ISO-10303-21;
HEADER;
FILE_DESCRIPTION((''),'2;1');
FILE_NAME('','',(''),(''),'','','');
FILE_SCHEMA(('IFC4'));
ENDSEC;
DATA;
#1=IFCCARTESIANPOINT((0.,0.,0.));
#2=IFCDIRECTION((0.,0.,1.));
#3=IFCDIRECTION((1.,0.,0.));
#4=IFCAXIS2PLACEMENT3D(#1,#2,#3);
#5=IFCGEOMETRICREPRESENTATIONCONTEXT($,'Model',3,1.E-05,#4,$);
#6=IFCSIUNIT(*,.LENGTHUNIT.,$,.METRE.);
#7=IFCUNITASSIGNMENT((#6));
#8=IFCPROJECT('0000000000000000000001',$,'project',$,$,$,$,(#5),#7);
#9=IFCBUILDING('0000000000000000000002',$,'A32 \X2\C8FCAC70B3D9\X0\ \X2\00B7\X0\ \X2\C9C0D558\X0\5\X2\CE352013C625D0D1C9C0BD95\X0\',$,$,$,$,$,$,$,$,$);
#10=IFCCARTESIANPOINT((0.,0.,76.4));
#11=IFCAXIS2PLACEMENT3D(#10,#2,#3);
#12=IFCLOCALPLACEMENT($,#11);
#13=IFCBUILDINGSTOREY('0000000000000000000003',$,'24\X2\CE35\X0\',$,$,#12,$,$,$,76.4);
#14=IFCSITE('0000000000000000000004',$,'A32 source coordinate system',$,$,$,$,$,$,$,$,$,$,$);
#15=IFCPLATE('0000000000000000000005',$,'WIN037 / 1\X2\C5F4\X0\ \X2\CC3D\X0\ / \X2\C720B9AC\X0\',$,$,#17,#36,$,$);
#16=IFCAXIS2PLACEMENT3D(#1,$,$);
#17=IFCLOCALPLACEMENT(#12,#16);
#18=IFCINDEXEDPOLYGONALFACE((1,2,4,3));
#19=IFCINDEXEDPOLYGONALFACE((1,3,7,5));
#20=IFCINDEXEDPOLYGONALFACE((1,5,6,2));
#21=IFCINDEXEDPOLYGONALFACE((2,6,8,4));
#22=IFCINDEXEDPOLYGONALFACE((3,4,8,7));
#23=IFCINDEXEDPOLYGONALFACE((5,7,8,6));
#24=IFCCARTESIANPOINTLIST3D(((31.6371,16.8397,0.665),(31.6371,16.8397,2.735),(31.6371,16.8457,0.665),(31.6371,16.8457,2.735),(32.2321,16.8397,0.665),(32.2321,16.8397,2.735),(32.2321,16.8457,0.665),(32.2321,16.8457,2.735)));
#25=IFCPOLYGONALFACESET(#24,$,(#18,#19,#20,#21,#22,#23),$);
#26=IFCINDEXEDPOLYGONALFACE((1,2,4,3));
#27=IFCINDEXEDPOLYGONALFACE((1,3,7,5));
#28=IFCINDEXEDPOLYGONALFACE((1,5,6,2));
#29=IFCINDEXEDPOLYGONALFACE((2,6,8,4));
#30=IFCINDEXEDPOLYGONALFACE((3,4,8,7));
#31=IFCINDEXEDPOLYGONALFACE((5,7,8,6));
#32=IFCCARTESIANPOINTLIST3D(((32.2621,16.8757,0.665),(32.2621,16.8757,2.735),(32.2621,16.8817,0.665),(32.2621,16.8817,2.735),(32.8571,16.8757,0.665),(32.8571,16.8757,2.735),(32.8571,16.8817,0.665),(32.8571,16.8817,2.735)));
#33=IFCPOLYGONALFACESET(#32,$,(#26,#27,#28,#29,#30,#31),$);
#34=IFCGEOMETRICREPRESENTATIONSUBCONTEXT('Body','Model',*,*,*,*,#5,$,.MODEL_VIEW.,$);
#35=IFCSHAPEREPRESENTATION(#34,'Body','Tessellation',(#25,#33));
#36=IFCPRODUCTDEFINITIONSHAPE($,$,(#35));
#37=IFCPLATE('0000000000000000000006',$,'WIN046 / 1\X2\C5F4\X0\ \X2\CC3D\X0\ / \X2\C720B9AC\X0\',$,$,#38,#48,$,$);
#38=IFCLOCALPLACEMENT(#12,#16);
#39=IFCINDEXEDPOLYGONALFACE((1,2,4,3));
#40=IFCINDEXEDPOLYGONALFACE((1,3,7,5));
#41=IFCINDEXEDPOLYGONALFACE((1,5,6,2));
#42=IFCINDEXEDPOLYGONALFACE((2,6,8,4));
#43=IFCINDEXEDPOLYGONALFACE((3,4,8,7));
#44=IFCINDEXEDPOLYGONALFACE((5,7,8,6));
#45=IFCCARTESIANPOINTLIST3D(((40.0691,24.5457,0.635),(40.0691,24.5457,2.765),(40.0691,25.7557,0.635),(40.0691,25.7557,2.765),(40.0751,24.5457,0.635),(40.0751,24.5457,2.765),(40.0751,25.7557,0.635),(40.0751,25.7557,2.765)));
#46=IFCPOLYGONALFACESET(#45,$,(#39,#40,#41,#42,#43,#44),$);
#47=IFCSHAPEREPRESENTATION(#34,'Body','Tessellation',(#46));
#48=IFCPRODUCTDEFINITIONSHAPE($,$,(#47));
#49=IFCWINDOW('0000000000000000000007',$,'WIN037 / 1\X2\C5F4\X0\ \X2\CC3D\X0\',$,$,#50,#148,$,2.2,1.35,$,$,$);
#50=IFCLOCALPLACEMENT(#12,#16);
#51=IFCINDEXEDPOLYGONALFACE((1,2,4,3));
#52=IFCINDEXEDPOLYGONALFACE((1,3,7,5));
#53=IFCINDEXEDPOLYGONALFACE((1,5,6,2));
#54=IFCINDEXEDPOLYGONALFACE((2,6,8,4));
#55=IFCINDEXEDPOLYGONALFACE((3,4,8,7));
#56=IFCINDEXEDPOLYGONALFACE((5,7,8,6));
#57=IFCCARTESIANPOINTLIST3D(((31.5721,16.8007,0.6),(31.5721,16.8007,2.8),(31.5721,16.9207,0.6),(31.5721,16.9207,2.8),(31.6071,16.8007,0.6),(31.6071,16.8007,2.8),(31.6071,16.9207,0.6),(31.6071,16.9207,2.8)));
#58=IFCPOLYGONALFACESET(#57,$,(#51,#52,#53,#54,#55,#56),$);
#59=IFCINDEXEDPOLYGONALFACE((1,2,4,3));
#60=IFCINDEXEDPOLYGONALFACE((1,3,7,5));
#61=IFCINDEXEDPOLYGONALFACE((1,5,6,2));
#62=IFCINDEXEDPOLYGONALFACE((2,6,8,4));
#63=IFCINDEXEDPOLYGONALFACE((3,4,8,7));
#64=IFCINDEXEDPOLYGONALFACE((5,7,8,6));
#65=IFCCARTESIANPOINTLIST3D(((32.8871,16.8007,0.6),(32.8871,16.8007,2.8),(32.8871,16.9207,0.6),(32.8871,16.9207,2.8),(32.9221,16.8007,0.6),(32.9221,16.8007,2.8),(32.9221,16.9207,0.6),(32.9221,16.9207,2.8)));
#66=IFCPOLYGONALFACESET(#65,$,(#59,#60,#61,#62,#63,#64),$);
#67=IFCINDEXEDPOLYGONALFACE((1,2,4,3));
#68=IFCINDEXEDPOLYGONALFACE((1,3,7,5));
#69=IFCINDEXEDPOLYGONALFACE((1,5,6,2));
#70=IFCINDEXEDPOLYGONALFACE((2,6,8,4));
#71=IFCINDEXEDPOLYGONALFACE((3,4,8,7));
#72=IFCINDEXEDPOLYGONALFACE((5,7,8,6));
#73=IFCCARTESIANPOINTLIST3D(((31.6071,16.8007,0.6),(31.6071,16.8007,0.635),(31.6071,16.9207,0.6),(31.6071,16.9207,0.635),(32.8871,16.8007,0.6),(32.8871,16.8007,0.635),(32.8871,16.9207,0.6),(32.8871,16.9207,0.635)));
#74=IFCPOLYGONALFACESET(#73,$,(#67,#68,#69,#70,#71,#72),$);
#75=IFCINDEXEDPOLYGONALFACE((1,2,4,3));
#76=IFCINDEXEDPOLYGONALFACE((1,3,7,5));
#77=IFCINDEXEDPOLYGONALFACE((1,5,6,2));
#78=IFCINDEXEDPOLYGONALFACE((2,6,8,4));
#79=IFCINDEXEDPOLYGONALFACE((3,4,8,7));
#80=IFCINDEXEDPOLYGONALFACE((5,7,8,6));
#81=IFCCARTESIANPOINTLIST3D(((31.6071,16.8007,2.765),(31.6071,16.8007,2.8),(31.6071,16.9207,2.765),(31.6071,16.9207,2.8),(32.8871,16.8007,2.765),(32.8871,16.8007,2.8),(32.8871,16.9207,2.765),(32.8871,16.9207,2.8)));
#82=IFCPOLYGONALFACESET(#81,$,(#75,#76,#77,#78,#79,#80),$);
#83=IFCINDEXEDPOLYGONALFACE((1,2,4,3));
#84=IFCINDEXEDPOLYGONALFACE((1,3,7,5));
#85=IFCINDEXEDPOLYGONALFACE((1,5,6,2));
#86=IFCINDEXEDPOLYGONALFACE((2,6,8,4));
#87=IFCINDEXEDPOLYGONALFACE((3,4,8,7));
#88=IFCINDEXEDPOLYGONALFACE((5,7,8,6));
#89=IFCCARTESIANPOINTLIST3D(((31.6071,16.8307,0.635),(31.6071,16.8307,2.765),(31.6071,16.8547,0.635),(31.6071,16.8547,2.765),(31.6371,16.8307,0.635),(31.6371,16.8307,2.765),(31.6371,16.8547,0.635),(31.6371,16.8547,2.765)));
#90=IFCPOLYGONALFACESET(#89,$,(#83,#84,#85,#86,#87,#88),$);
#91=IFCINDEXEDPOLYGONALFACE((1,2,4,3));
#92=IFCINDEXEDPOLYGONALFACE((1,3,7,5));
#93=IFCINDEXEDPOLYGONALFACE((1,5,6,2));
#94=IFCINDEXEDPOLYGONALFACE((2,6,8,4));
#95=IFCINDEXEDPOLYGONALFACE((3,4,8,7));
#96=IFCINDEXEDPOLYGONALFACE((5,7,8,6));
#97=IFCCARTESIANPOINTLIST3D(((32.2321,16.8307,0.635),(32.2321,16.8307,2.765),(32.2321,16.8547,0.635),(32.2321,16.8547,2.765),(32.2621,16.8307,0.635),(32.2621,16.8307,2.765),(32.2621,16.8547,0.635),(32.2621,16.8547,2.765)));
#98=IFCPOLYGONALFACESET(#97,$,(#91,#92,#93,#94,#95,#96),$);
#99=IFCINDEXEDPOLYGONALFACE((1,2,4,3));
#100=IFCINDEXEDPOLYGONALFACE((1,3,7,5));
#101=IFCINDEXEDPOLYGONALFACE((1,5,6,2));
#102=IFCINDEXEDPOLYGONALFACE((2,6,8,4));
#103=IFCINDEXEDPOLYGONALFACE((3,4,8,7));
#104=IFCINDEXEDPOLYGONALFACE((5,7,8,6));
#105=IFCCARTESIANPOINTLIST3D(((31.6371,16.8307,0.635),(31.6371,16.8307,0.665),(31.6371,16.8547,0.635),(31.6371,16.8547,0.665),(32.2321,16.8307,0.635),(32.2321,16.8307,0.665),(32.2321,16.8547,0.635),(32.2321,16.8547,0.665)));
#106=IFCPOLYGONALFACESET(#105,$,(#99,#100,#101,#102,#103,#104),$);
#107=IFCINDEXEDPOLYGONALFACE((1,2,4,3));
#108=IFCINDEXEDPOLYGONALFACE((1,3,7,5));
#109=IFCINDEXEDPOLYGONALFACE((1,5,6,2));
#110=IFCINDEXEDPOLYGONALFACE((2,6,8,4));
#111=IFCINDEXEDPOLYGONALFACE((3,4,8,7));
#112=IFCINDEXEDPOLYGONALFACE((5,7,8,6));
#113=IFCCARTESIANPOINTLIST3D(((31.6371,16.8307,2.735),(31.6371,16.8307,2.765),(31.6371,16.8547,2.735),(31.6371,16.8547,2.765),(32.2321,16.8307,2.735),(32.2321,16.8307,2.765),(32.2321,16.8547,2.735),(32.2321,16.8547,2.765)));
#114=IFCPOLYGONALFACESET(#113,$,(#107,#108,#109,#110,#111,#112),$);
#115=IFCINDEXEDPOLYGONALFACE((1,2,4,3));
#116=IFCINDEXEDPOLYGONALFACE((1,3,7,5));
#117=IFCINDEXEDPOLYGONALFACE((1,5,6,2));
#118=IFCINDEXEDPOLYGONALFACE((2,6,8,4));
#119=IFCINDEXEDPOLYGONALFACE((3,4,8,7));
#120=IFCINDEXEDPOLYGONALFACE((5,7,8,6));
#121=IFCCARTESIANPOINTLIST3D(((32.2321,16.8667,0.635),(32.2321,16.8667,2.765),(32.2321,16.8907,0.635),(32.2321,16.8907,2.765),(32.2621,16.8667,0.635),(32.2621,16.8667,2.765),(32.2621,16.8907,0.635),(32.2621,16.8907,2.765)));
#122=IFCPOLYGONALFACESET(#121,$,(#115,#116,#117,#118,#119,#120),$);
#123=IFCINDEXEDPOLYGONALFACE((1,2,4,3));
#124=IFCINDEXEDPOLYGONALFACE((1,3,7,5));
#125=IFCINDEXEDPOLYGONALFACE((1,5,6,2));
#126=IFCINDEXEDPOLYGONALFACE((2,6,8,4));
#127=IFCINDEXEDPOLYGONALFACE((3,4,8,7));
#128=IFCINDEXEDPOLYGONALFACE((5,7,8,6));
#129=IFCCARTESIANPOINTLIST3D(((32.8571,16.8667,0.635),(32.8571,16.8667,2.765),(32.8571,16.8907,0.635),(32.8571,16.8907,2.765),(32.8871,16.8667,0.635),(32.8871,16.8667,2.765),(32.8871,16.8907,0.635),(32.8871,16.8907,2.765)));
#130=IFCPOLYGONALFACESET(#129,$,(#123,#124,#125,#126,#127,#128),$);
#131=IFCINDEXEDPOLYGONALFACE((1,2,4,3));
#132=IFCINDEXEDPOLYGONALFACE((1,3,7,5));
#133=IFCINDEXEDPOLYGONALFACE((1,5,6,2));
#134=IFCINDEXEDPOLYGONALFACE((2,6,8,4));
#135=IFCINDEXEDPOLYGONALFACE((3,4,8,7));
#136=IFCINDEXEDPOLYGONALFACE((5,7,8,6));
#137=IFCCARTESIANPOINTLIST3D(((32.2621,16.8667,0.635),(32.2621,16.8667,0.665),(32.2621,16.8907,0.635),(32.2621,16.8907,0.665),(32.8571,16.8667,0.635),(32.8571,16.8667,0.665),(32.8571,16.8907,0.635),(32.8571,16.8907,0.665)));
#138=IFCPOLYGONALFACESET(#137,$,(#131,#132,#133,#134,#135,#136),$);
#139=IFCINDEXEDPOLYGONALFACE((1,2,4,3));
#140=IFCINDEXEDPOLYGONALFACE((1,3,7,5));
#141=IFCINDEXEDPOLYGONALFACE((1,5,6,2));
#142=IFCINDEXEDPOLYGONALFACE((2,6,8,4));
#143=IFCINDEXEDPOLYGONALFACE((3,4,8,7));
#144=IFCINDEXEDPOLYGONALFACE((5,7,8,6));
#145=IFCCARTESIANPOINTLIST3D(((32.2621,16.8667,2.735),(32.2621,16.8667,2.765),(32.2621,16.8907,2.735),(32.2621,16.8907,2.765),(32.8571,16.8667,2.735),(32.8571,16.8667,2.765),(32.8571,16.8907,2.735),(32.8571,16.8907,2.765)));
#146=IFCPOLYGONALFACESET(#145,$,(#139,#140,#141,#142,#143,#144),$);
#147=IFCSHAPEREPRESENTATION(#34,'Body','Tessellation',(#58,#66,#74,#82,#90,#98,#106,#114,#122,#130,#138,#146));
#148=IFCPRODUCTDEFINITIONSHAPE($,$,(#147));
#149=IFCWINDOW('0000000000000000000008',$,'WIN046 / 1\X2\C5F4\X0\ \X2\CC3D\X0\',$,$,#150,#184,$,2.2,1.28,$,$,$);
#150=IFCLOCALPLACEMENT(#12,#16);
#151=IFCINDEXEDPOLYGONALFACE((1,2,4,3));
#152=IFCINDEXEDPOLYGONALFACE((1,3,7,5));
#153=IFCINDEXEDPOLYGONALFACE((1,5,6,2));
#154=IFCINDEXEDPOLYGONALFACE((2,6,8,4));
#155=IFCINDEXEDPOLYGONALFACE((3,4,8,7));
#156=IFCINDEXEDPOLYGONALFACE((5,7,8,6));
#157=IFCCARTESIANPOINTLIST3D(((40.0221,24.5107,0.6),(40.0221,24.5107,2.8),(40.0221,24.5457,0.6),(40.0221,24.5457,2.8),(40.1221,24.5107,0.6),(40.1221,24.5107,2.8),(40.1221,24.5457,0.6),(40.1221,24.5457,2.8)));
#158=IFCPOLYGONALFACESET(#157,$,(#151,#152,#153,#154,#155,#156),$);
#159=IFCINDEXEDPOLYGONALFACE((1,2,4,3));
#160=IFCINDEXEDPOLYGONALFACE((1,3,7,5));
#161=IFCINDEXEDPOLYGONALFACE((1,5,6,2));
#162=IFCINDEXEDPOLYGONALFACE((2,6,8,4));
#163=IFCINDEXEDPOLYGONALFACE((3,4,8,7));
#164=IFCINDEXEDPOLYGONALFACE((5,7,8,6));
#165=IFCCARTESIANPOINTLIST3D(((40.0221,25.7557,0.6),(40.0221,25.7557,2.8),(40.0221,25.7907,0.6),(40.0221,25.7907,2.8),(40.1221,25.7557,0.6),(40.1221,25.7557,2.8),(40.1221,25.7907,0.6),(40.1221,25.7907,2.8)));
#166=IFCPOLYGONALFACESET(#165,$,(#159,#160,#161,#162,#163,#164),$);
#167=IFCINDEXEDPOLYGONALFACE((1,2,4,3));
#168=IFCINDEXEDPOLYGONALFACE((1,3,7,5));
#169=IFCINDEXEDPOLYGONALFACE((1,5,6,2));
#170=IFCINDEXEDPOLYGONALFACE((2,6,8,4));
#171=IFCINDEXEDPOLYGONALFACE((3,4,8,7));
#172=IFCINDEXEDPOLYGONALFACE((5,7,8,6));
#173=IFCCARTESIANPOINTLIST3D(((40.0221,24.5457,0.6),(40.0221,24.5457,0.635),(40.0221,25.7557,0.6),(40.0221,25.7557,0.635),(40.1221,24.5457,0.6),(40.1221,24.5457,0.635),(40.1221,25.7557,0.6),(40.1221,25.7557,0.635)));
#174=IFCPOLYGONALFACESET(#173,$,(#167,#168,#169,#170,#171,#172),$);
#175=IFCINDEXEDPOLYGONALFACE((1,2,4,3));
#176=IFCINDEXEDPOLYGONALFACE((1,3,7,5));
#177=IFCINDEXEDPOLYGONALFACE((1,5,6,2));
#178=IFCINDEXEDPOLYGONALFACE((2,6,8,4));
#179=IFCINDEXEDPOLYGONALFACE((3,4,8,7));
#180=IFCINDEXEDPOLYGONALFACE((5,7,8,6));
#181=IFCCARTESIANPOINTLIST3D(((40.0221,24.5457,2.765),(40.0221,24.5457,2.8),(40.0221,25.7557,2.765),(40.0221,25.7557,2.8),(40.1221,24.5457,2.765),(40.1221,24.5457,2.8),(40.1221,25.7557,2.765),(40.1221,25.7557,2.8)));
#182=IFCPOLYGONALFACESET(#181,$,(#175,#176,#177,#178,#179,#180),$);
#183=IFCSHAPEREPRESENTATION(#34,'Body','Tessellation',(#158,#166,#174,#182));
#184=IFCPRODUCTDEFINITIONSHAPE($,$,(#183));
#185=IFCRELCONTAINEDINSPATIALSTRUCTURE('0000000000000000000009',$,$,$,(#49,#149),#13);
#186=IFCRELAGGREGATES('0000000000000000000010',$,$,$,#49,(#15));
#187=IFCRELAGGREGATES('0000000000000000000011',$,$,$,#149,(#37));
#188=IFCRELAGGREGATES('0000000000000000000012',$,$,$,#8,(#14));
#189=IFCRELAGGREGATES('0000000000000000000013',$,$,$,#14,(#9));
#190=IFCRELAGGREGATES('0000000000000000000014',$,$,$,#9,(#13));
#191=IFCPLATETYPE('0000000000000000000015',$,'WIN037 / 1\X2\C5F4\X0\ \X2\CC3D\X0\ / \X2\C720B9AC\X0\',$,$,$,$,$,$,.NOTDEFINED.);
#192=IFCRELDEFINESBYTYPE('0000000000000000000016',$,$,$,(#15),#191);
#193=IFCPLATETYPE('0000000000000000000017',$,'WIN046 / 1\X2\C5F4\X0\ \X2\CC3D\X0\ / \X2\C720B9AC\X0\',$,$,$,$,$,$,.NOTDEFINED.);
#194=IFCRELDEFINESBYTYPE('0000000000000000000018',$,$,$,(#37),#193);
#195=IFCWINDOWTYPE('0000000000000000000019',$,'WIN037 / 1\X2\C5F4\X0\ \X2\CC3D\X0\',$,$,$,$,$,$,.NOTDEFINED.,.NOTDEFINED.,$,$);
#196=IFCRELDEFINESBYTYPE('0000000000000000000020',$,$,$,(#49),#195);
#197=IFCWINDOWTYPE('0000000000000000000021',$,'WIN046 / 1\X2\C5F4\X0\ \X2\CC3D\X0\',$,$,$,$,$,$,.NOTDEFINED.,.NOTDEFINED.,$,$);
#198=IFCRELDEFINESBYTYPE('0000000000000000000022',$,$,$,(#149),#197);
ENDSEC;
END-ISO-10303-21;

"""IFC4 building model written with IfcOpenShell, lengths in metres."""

from ifc_helpers import new_model, si_unit, frame, origin, origin_with_axes, place, context, subcontext, project, spatial, polyline, outline, extrude, source, transform, mapped, type_object, type_shapes, element, aggregate, save


model = new_model("IFC4")

# Units and contexts
model_context = context("Model", 3, precision=1e-05, world=origin_with_axes())
body_context = subcontext(model_context, "Body", "Model", "MODEL_VIEW")
ifc_project = project(units=[si_unit("LENGTHUNIT", "METRE")], contexts=[model_context])

# Site, building, storey
site = spatial("IfcSite", under=ifc_project, Name="A32 source coordinate system")
building = spatial("IfcBuilding", under=site, Name="A32 주거동 · 지하5층–옥탑지붕")
storey_placement = place(None, frame((0.0, 0.0, 76.4), z_axis=(0.0, 0.0, 1.0), x_axis=(1.0, 0.0, 0.0)))
storey = spatial("IfcBuildingStorey", under=building, at=storey_placement, Name="24층", Elevation=76.4)

# Plates
plate_type_1 = type_object("IfcPlateType", Name="WIN037 / 1열 창 / 유리", PredefinedType="NOTDEFINED")
shared_shape_1 = source(origin(), body_context, "Body", "SweptSolid", [
    extrude(outline(polyline([(31.6371, 16.8397), (31.6371, 16.8457), (32.2321, 16.8457), (32.2321, 16.8397), (31.6371, 16.8397)])), frame((0.0, 0.0, 0.665)), (0.0, 0.0, 1.0), 2.07),
    extrude(outline(polyline([(32.2621, 16.8757), (32.2621, 16.8817), (32.8571, 16.8817), (32.8571, 16.8757), (32.2621, 16.8757)])), frame((0.0, 0.0, 0.665)), (0.0, 0.0, 1.0), 2.07),
])
type_shapes(plate_type_1, [shared_shape_1])
window_1_placement = place(storey_placement, origin_with_axes())
plate_1_placement = place(window_1_placement, origin_with_axes())
plate_1 = element("IfcPlate", 1, at=plate_1_placement, type_object=plate_type_1, Name="WIN037 / 1열 창 / 유리", context=body_context, shape_type="MappedRepresentation", body=[
    mapped(shared_shape_1, transform((0.0, 0.0, 0.0), scale=1.0)),
])
plate_type_2 = type_object("IfcPlateType", Name="WIN046 / 1열 창 / 유리", PredefinedType="NOTDEFINED")
shared_shape_2 = source(origin(), body_context, "Body", "SweptSolid", [
    extrude(outline(polyline([(40.0691, 24.5457), (40.0691, 25.7557), (40.0751, 25.7557), (40.0751, 24.5457), (40.0691, 24.5457)])), frame((0.0, 0.0, 0.635)), (0.0, 0.0, 1.0), 2.13),
])
type_shapes(plate_type_2, [shared_shape_2])
window_2_placement = place(storey_placement, origin_with_axes())
plate_2_placement = place(window_2_placement, origin_with_axes())
plate_2 = element("IfcPlate", 2, at=plate_2_placement, type_object=plate_type_2, Name="WIN046 / 1열 창 / 유리", context=body_context, shape_type="MappedRepresentation", body=[
    mapped(shared_shape_2, transform((0.0, 0.0, 0.0), scale=1.0)),
])

# Windows
window_type_1 = type_object("IfcWindowType", Name="WIN037 / 1열 창", PartitioningType="NOTDEFINED", PredefinedType="NOTDEFINED")
shared_shape_3 = source(origin(), body_context, "Body", "SweptSolid", [
    extrude(outline(polyline([(31.5721, 16.8007), (31.5721, 16.9207), (31.6071, 16.9207), (31.6071, 16.8007), (31.5721, 16.8007)])), frame((0.0, 0.0, 0.6)), (0.0, 0.0, 1.0), 2.2),
    extrude(outline(polyline([(32.8871, 16.8007), (32.8871, 16.9207), (32.9221, 16.9207), (32.9221, 16.8007), (32.8871, 16.8007)])), frame((0.0, 0.0, 0.6)), (0.0, 0.0, 1.0), 2.2),
    extrude(outline(polyline([(31.6071, 16.8007), (31.6071, 16.9207), (32.8871, 16.9207), (32.8871, 16.8007), (31.6071, 16.8007)])), frame((0.0, 0.0, 0.6)), (0.0, 0.0, 1.0), 0.035),
    extrude(outline(polyline([(31.6071, 16.8007), (31.6071, 16.9207), (32.8871, 16.9207), (32.8871, 16.8007), (31.6071, 16.8007)])), frame((0.0, 0.0, 2.765)), (0.0, 0.0, 1.0), 0.035),
    extrude(outline(polyline([(31.6071, 16.8307), (31.6071, 16.8547), (31.6371, 16.8547), (31.6371, 16.8307), (31.6071, 16.8307)])), frame((0.0, 0.0, 0.635)), (0.0, 0.0, 1.0), 2.13),
    extrude(outline(polyline([(32.2321, 16.8307), (32.2321, 16.8547), (32.2621, 16.8547), (32.2621, 16.8307), (32.2321, 16.8307)])), frame((0.0, 0.0, 0.635)), (0.0, 0.0, 1.0), 2.13),
    extrude(outline(polyline([(31.6371, 16.8307), (31.6371, 16.8547), (32.2321, 16.8547), (32.2321, 16.8307), (31.6371, 16.8307)])), frame((0.0, 0.0, 0.635)), (0.0, 0.0, 1.0), 0.03),
    extrude(outline(polyline([(31.6371, 16.8307), (31.6371, 16.8547), (32.2321, 16.8547), (32.2321, 16.8307), (31.6371, 16.8307)])), frame((0.0, 0.0, 2.735)), (0.0, 0.0, 1.0), 0.03),
    extrude(outline(polyline([(32.2321, 16.8667), (32.2321, 16.8907), (32.2621, 16.8907), (32.2621, 16.8667), (32.2321, 16.8667)])), frame((0.0, 0.0, 0.635)), (0.0, 0.0, 1.0), 2.13),
    extrude(outline(polyline([(32.8571, 16.8667), (32.8571, 16.8907), (32.8871, 16.8907), (32.8871, 16.8667), (32.8571, 16.8667)])), frame((0.0, 0.0, 0.635)), (0.0, 0.0, 1.0), 2.13),
    extrude(outline(polyline([(32.2621, 16.8667), (32.2621, 16.8907), (32.8571, 16.8907), (32.8571, 16.8667), (32.2621, 16.8667)])), frame((0.0, 0.0, 0.635)), (0.0, 0.0, 1.0), 0.03),
    extrude(outline(polyline([(32.2621, 16.8667), (32.2621, 16.8907), (32.8571, 16.8907), (32.8571, 16.8667), (32.2621, 16.8667)])), frame((0.0, 0.0, 2.735)), (0.0, 0.0, 1.0), 0.03),
])
type_shapes(window_type_1, [shared_shape_3])
window_1 = element("IfcWindow", 3, at=window_1_placement, inside=storey, type_object=window_type_1, Name="WIN037 / 1열 창", OverallHeight=2.2, OverallWidth=1.35, context=body_context, shape_type="MappedRepresentation", body=[
    mapped(shared_shape_3, transform((0.0, 0.0, 0.0), scale=1.0)),
])
aggregate(window_1, [plate_1])
window_type_2 = type_object("IfcWindowType", Name="WIN046 / 1열 창", PartitioningType="NOTDEFINED", PredefinedType="NOTDEFINED")
shared_shape_4 = source(origin(), body_context, "Body", "SweptSolid", [
    extrude(outline(polyline([(40.0221, 24.5107), (40.0221, 24.5457), (40.1221, 24.5457), (40.1221, 24.5107), (40.0221, 24.5107)])), frame((0.0, 0.0, 0.6)), (0.0, 0.0, 1.0), 2.2),
    extrude(outline(polyline([(40.0221, 25.7557), (40.0221, 25.7907), (40.1221, 25.7907), (40.1221, 25.7557), (40.0221, 25.7557)])), frame((0.0, 0.0, 0.6)), (0.0, 0.0, 1.0), 2.2),
    extrude(outline(polyline([(40.0221, 24.5457), (40.0221, 25.7557), (40.1221, 25.7557), (40.1221, 24.5457), (40.0221, 24.5457)])), frame((0.0, 0.0, 0.6)), (0.0, 0.0, 1.0), 0.035),
    extrude(outline(polyline([(40.0221, 24.5457), (40.0221, 25.7557), (40.1221, 25.7557), (40.1221, 24.5457), (40.0221, 24.5457)])), frame((0.0, 0.0, 2.765)), (0.0, 0.0, 1.0), 0.035),
])
type_shapes(window_type_2, [shared_shape_4])
window_2 = element("IfcWindow", 4, at=window_2_placement, inside=storey, type_object=window_type_2, Name="WIN046 / 1열 창", OverallHeight=2.2, OverallWidth=1.28, context=body_context, shape_type="MappedRepresentation", body=[
    mapped(shared_shape_4, transform((0.0, 0.0, 0.0), scale=1.0)),
])
aggregate(window_2, [plate_2])

save(model, "model.ifc")
